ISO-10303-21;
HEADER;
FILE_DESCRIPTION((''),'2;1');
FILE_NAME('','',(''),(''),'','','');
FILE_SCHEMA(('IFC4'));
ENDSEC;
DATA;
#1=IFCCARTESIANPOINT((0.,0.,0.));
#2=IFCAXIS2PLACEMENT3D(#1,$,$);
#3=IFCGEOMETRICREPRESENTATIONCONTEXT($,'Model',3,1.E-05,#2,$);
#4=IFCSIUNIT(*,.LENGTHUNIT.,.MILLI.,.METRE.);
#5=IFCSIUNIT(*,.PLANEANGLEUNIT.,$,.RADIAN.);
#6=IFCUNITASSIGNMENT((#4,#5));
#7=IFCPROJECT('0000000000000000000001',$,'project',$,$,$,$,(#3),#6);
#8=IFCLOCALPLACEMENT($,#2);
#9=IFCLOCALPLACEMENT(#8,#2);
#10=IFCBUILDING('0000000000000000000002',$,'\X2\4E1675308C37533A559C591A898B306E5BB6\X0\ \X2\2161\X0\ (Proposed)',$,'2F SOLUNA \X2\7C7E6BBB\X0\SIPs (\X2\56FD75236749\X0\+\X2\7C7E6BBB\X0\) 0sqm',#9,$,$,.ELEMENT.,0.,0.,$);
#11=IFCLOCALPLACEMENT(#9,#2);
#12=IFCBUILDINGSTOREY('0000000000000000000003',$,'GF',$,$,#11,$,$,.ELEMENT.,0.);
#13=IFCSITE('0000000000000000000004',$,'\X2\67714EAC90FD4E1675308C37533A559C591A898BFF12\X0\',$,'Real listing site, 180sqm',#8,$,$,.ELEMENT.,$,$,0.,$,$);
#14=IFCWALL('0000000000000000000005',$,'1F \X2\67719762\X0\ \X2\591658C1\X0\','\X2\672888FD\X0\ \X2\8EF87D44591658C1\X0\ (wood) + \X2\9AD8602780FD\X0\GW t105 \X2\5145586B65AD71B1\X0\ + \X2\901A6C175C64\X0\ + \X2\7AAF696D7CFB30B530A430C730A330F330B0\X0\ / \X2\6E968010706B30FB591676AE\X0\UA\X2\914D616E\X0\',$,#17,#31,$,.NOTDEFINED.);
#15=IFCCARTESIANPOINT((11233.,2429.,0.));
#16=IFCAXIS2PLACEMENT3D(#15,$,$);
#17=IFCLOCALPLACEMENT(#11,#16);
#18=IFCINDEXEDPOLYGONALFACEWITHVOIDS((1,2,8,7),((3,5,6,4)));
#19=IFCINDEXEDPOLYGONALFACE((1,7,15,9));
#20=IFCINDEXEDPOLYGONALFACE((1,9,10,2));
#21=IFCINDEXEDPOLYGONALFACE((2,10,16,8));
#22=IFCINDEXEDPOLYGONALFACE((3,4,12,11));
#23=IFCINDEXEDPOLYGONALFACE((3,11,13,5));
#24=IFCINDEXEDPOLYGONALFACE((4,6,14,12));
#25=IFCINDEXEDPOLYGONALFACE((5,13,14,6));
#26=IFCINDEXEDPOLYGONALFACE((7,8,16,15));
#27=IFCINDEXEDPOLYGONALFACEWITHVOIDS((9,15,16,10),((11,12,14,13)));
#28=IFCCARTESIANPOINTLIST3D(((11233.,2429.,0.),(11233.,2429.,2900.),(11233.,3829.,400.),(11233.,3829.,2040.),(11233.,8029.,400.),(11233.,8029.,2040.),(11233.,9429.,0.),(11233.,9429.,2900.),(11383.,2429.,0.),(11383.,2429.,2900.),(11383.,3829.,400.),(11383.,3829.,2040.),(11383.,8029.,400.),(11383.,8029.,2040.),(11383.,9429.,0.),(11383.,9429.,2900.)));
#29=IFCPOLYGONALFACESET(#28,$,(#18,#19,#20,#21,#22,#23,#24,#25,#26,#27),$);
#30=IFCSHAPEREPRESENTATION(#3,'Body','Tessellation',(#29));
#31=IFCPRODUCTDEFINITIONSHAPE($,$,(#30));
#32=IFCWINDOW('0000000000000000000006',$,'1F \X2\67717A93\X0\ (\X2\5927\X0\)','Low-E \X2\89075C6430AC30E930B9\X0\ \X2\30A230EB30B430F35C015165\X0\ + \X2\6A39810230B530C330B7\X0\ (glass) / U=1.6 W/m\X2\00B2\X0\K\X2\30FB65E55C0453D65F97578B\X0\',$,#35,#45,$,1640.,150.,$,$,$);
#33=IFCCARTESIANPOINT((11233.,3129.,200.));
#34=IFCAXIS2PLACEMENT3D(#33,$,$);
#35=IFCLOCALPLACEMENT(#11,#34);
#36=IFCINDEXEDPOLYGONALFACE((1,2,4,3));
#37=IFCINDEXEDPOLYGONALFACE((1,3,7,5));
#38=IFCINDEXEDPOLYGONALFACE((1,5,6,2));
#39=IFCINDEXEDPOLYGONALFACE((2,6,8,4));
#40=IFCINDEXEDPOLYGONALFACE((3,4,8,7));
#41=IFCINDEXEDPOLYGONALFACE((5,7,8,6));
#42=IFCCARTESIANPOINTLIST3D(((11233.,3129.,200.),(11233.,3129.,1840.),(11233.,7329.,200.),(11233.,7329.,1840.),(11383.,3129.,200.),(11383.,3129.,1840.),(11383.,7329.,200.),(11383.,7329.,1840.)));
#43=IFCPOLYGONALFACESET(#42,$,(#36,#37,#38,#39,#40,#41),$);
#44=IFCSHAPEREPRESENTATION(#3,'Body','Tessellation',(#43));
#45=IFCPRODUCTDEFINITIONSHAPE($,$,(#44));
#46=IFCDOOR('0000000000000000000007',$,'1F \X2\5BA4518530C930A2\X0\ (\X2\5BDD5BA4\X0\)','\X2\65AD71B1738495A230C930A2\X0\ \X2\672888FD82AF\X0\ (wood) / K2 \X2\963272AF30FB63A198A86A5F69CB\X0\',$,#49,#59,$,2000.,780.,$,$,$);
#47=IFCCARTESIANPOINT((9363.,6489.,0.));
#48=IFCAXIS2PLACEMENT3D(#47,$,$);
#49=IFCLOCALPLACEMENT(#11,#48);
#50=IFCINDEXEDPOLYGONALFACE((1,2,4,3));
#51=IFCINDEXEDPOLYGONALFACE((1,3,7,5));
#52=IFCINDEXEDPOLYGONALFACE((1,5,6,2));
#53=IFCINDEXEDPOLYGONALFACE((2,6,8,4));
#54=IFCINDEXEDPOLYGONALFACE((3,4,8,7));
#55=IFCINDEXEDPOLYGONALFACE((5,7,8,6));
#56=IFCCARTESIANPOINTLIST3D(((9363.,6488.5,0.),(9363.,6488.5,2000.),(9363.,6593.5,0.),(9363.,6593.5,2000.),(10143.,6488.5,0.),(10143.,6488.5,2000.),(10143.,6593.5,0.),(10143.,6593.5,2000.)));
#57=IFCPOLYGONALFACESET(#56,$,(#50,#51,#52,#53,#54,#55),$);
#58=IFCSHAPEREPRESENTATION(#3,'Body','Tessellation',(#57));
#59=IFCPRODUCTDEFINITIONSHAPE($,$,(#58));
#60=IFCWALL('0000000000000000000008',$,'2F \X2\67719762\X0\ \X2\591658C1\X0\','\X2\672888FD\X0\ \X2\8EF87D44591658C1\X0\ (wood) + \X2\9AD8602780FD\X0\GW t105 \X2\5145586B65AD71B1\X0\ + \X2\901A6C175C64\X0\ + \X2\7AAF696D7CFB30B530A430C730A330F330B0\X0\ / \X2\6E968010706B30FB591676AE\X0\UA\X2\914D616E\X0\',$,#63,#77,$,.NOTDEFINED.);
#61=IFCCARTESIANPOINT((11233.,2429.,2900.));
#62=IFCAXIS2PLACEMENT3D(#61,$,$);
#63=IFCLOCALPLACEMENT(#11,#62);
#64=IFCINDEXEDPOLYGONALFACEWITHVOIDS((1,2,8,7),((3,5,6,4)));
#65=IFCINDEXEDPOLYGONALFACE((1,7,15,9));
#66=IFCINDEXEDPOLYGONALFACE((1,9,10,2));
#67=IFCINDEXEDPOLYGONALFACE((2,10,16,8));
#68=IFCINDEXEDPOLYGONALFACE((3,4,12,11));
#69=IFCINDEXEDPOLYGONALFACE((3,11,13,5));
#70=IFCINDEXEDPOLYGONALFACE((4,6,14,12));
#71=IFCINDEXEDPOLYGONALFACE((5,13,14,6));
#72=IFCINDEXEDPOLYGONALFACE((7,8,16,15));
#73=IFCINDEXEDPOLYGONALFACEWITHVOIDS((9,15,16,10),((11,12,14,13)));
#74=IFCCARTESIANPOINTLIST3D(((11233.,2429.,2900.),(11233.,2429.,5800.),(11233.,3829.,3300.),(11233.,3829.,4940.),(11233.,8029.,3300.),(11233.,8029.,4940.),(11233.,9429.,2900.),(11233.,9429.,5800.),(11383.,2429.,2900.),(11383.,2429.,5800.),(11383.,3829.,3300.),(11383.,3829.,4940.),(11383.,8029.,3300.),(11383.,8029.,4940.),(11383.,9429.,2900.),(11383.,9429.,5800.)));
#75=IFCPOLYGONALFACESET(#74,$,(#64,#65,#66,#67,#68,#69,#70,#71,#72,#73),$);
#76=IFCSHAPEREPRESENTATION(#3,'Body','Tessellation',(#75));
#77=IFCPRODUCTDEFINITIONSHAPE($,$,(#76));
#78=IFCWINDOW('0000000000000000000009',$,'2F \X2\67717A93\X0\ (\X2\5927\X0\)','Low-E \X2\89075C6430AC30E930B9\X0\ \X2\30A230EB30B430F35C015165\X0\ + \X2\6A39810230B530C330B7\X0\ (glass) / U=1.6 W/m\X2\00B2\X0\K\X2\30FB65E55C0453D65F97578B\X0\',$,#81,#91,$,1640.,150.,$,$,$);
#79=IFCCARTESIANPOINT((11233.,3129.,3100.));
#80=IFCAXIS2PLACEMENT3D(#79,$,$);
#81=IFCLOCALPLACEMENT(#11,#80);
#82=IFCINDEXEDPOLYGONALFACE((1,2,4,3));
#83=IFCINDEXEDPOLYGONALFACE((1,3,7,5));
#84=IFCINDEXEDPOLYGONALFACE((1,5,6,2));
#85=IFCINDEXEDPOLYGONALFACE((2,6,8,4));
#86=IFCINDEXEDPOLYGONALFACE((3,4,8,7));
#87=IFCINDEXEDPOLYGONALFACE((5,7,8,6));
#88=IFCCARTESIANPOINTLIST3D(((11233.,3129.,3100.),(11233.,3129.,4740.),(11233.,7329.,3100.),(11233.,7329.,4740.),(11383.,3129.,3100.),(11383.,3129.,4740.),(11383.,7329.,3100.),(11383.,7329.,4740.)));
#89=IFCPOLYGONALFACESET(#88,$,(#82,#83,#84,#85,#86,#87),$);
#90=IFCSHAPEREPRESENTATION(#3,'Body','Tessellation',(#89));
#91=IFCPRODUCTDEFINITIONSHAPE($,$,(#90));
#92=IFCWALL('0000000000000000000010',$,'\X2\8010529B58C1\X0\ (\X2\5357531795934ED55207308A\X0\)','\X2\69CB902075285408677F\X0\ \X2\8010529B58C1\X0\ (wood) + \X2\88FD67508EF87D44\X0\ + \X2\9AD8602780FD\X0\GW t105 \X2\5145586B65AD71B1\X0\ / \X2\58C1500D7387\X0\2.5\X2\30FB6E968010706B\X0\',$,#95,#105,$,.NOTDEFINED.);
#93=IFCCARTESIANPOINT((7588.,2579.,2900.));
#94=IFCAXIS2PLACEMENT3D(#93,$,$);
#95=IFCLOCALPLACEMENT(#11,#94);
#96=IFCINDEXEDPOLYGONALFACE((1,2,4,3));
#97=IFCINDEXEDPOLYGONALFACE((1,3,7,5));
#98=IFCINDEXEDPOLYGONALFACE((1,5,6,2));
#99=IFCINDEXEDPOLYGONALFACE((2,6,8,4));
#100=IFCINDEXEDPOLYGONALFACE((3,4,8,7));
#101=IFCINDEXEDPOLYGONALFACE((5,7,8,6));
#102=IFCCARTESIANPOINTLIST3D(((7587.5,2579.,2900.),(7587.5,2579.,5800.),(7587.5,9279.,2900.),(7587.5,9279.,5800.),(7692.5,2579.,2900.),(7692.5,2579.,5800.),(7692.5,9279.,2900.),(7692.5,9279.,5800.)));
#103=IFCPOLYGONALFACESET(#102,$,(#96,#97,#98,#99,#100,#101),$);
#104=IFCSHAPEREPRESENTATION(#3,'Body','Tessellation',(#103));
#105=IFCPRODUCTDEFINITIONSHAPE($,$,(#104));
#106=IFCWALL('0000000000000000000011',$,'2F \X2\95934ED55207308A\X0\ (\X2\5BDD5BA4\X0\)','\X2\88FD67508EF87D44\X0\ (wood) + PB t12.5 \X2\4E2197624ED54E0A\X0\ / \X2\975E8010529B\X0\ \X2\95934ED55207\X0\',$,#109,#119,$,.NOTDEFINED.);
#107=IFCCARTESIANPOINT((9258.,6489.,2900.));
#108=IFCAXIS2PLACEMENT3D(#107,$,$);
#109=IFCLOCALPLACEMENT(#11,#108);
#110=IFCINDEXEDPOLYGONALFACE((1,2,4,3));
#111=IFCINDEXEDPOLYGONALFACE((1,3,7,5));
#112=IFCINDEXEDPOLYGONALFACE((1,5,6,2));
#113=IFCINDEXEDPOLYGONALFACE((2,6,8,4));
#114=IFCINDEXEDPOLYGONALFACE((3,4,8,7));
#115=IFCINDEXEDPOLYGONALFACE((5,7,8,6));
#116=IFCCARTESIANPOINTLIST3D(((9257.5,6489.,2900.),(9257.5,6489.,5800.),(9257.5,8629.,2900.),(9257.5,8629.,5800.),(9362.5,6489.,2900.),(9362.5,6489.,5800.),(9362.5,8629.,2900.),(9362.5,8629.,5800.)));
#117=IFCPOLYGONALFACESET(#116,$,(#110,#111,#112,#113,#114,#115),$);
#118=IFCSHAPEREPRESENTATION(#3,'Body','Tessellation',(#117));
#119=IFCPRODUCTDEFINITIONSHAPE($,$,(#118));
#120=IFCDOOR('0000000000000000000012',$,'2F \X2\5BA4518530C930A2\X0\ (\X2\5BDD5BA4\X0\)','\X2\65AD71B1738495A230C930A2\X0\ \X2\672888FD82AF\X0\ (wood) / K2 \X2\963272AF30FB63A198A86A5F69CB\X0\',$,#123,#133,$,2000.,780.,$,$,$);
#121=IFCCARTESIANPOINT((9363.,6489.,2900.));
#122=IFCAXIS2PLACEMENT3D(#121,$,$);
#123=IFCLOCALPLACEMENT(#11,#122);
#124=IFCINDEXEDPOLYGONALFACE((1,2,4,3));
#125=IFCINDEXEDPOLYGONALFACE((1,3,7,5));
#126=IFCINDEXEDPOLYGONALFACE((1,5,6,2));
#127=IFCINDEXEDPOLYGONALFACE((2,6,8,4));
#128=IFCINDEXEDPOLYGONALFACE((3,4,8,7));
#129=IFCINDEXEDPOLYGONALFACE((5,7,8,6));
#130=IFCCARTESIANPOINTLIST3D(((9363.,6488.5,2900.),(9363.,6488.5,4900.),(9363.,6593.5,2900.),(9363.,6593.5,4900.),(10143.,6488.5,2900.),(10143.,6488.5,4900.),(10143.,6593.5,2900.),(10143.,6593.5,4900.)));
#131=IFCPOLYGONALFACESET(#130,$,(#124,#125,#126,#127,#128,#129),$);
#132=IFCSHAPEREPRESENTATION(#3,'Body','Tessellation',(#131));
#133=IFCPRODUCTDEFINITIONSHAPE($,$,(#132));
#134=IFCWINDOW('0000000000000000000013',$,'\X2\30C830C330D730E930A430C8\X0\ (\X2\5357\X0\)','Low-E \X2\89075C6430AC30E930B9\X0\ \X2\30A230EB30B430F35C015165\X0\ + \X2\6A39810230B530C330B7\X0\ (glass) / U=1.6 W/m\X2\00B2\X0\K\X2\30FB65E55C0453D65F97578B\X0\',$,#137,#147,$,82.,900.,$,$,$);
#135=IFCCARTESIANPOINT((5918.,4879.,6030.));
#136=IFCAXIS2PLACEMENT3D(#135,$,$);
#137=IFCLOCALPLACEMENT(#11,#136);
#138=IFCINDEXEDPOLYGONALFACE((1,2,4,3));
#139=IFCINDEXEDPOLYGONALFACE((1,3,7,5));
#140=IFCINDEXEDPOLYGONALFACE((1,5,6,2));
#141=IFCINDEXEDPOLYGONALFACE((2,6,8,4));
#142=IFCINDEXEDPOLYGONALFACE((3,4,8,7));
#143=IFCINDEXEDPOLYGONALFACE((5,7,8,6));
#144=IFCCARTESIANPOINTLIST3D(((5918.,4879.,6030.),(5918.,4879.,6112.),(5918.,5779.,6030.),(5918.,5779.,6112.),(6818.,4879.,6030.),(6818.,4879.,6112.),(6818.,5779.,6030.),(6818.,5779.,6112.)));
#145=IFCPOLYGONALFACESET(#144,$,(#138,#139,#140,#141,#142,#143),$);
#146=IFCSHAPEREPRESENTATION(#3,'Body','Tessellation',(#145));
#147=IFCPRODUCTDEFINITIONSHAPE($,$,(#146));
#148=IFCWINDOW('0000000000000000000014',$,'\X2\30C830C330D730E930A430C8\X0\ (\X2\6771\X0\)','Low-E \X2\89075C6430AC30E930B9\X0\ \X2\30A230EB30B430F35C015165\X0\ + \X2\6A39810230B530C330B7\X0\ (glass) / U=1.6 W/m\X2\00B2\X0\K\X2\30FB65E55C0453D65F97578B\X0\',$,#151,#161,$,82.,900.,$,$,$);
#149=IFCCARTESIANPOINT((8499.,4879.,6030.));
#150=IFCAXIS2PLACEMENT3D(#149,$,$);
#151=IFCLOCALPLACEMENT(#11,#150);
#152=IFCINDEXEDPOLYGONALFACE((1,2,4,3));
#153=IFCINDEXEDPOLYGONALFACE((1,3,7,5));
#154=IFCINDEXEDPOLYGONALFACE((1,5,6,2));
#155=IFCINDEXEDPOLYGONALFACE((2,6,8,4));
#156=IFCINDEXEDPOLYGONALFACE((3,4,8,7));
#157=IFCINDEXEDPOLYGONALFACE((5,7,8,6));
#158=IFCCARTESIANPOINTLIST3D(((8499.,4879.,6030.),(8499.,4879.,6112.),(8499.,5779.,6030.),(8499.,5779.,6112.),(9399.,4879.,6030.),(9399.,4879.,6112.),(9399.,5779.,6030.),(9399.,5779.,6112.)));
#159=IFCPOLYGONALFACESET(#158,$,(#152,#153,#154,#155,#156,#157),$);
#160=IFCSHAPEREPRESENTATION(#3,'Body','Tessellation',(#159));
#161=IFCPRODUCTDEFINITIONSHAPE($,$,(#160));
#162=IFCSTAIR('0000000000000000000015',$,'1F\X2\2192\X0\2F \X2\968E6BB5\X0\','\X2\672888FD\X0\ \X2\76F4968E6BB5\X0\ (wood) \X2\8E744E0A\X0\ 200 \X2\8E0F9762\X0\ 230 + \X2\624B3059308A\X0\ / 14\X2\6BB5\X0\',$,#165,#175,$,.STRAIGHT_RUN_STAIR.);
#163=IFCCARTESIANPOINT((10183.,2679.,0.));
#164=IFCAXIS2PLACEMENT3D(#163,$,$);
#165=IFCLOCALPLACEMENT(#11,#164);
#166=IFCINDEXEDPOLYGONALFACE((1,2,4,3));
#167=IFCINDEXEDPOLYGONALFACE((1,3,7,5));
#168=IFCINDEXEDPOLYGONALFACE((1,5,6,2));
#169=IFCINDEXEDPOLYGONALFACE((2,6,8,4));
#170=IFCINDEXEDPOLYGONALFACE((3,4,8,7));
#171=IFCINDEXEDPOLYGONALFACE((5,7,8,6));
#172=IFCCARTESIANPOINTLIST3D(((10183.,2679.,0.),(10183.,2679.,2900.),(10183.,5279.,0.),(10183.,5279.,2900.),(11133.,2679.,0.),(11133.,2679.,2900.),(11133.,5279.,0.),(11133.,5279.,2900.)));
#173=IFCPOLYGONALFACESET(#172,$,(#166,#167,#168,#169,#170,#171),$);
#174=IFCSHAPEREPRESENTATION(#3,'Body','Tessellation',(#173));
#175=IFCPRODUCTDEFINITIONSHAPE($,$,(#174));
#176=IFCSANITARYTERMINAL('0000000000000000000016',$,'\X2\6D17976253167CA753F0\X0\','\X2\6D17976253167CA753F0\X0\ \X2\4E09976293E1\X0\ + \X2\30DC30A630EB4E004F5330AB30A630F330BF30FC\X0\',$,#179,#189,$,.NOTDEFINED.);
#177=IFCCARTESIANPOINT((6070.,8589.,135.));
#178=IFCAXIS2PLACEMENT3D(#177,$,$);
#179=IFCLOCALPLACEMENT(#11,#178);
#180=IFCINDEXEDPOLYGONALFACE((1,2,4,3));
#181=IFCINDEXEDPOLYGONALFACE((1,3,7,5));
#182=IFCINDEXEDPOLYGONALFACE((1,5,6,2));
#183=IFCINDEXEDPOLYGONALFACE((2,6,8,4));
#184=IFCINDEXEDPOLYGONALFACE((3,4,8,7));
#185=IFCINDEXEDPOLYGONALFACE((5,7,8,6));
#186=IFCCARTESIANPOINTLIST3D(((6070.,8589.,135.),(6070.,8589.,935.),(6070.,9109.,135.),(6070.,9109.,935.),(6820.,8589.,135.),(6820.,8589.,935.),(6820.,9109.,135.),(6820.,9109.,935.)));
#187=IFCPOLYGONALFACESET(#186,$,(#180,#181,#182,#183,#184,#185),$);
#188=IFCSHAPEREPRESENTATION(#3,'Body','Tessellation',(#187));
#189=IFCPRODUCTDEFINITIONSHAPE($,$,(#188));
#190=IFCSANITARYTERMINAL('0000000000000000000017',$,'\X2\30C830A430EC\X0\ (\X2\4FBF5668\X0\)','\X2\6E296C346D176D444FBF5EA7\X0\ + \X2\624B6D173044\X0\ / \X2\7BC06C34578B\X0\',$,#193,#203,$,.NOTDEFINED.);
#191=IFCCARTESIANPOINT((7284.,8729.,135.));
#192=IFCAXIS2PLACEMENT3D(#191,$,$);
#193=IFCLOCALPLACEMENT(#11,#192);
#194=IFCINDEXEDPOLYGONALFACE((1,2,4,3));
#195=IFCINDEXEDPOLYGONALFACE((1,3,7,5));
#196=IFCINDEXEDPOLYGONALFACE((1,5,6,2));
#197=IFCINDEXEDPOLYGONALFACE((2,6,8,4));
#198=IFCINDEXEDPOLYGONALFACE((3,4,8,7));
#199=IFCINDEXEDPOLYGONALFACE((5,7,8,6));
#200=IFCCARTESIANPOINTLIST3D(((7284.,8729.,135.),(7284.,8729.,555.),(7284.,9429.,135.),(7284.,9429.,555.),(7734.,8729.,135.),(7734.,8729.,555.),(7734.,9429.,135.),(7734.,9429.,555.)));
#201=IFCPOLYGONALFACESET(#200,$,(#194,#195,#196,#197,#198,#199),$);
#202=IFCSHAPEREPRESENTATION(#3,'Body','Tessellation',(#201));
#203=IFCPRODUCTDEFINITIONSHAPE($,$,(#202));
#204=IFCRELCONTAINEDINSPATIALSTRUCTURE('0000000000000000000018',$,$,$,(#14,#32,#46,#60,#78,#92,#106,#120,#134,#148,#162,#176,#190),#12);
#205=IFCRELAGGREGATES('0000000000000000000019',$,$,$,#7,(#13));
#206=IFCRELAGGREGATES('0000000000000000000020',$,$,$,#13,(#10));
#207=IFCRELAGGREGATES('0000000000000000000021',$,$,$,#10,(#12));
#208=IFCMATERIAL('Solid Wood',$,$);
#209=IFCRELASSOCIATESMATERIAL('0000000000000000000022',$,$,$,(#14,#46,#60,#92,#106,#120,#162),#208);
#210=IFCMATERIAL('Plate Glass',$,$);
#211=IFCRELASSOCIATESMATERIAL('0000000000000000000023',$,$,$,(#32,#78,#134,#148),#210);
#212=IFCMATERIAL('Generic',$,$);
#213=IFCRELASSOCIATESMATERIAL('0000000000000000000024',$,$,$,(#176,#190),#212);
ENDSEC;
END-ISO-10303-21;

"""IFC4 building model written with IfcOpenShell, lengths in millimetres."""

from ifc_helpers import new_model, si_unit, frame, frame_2d, origin, place, context, project, spatial, rectangle, extrude, material, element, fill, save


model = new_model("IFC4")

# Units and contexts
model_context = context("Model", 3, precision=1e-05, world=origin())
ifc_project = project(units=[si_unit("LENGTHUNIT", "METRE", prefix="MILLI"), si_unit("PLANEANGLEUNIT", "RADIAN")], contexts=[model_context])

# Site, building, storey
site_placement = place(None, origin())
site = spatial("IfcSite", under=ifc_project, at=site_placement, Name="東京都世田谷区喜多見２", ObjectType="Real listing site, 180sqm", CompositionType="ELEMENT", RefElevation=0.0)
building_placement = place(site_placement, origin())
building = spatial("IfcBuilding", under=site, at=building_placement, Name="世田谷区喜多見の家 Ⅱ (Proposed)", ObjectType="2F SOLUNA 籾殻SIPs (国産杉+籾殻) 0sqm", CompositionType="ELEMENT", ElevationOfRefHeight=0.0, ElevationOfTerrain=0.0)
storey_placement = place(building_placement, origin())
storey = spatial("IfcBuildingStorey", under=building, at=storey_placement, Name="GF", CompositionType="ELEMENT", Elevation=0.0)

# Wall, opening, window
ifc_material_1 = material(Name="Solid Wood")
wall_1_placement = place(storey_placement, frame((11233.0, 2429.0, 0.0)))
wall_1 = element("IfcWall", 1, at=wall_1_placement, inside=storey, material=ifc_material_1, Name="1F 東面 外壁", Description="木製 軸組外壁 (wood) + 高性能GW t105 充填断熱 + 通気層 + 窯業系サイディング / 準耐火・外皮UA配慮", PredefinedType="NOTDEFINED", context=model_context, shape_type="SweptSolid", body=[
    extrude(rectangle(XDim=150.0, YDim=7000.0, at=frame_2d((75.0, 3500.0))), frame((11233.0, 2429.0, 0.0)), (0.0, 0.0, 1.0), 2900.0),
])
opening_1_placement = place(storey_placement, frame((11233.0, 3129.0, 200.0)))
opening_1 = element("IfcOpeningElement", 2, at=opening_1_placement, cuts=wall_1, PredefinedType="NOTDEFINED", context=model_context, shape_type="SweptSolid", body=[
    extrude(rectangle(XDim=150.0, YDim=4200.0, at=frame_2d((75.0, 2100.0))), frame((11233.0, 3129.0, 200.0)), (0.0, 0.0, 1.0), 1640.0),
])
ifc_material_2 = material(Name="Plate Glass")
window_1_placement = place(storey_placement, frame((11233.0, 3129.0, 200.0)))
window_1 = element("IfcWindow", 3, at=window_1_placement, inside=storey, material=ifc_material_2, Name="1F 東窓 (大)", Description="Low-E 複層ガラス アルゴン封入 + 樹脂サッシ (glass) / U=1.6 W/m²K・日射取得型", OverallHeight=1640.0, OverallWidth=150.0, context=model_context, shape_type="SweptSolid", body=[
    extrude(rectangle(XDim=150.0, YDim=4200.0, at=frame_2d((75.0, 2100.0))), frame((11233.0, 3129.0, 200.0)), (0.0, 0.0, 1.0), 1640.0),
])
fill(opening_1, window_1)

# Door
door_1_placement = place(storey_placement, frame((9363.0, 6489.0, 0.0)))
element("IfcDoor", 4, at=door_1_placement, inside=storey, material=ifc_material_1, Name="1F 室内ドア (寝室)", Description="断熱玄関ドア 木製芯 (wood) / K2 防犯・採風機構", OverallHeight=2000.0, OverallWidth=780.0, context=model_context, shape_type="SweptSolid", body=[
    extrude(rectangle(XDim=780.0, YDim=105.0, at=frame_2d((390.0, 52.0))), frame((9363.0, 6489.0, 0.0)), (0.0, 0.0, 1.0), 2000.0),
])

# Wall, opening, window
wall_2_placement = place(storey_placement, frame((11233.0, 2429.0, 2900.0)))
wall_2 = element("IfcWall", 5, at=wall_2_placement, inside=storey, material=ifc_material_1, Name="2F 東面 外壁", Description="木製 軸組外壁 (wood) + 高性能GW t105 充填断熱 + 通気層 + 窯業系サイディング / 準耐火・外皮UA配慮", PredefinedType="NOTDEFINED", context=model_context, shape_type="SweptSolid", body=[
    extrude(rectangle(XDim=150.0, YDim=7000.0, at=frame_2d((75.0, 3500.0))), frame((11233.0, 2429.0, 2900.0)), (0.0, 0.0, 1.0), 2900.0),
])
opening_2_placement = place(storey_placement, frame((11233.0, 3129.0, 3100.0)))
opening_2 = element("IfcOpeningElement", 6, at=opening_2_placement, cuts=wall_2, PredefinedType="NOTDEFINED", context=model_context, shape_type="SweptSolid", body=[
    extrude(rectangle(XDim=150.0, YDim=4200.0, at=frame_2d((75.0, 2100.0))), frame((11233.0, 3129.0, 3100.0)), (0.0, 0.0, 1.0), 1640.0),
])
window_2_placement = place(storey_placement, frame((11233.0, 3129.0, 3100.0)))
window_2 = element("IfcWindow", 7, at=window_2_placement, inside=storey, material=ifc_material_2, Name="2F 東窓 (大)", Description="Low-E 複層ガラス アルゴン封入 + 樹脂サッシ (glass) / U=1.6 W/m²K・日射取得型", OverallHeight=1640.0, OverallWidth=150.0, context=model_context, shape_type="SweptSolid", body=[
    extrude(rectangle(XDim=150.0, YDim=4200.0, at=frame_2d((75.0, 2100.0))), frame((11233.0, 3129.0, 3100.0)), (0.0, 0.0, 1.0), 1640.0),
])
fill(opening_2, window_2)

# Walls
wall_3_placement = place(storey_placement, frame((7588.0, 2579.0, 2900.0)))
element("IfcWall", 8, at=wall_3_placement, inside=storey, material=ifc_material_1, Name="耐力壁 (南北間仕切り)", Description="構造用合板 耐力壁 (wood) + 製材軸組 + 高性能GW t105 充填断熱 / 壁倍率2.5・準耐火", PredefinedType="NOTDEFINED", context=model_context, shape_type="SweptSolid", body=[
    extrude(rectangle(XDim=105.0, YDim=6700.0, at=frame_2d((52.0, 3350.0))), frame((7588.0, 2579.0, 2900.0)), (0.0, 0.0, 1.0), 2900.0),
])
wall_4_placement = place(storey_placement, frame((9258.0, 6489.0, 2900.0)))
element("IfcWall", 9, at=wall_4_placement, inside=storey, material=ifc_material_1, Name="2F 間仕切り (寝室)", Description="製材軸組 (wood) + PB t12.5 両面仕上 / 非耐力 間仕切", PredefinedType="NOTDEFINED", context=model_context, shape_type="SweptSolid", body=[
    extrude(rectangle(XDim=105.0, YDim=2140.0, at=frame_2d((52.0, 1070.0))), frame((9258.0, 6489.0, 2900.0)), (0.0, 0.0, 1.0), 2900.0),
])

# Door
door_2_placement = place(storey_placement, frame((9363.0, 6489.0, 2900.0)))
element("IfcDoor", 10, at=door_2_placement, inside=storey, material=ifc_material_1, Name="2F 室内ドア (寝室)", Description="断熱玄関ドア 木製芯 (wood) / K2 防犯・採風機構", OverallHeight=2000.0, OverallWidth=780.0, context=model_context, shape_type="SweptSolid", body=[
    extrude(rectangle(XDim=780.0, YDim=105.0, at=frame_2d((390.0, 52.0))), frame((9363.0, 6489.0, 2900.0)), (0.0, 0.0, 1.0), 2000.0),
])

# Windows
window_3_placement = place(storey_placement, frame((5918.0, 4879.0, 6030.0)))
element("IfcWindow", 11, at=window_3_placement, inside=storey, material=ifc_material_2, Name="トップライト (南)", Description="Low-E 複層ガラス アルゴン封入 + 樹脂サッシ (glass) / U=1.6 W/m²K・日射取得型", OverallHeight=82.0, OverallWidth=900.0, context=model_context, shape_type="SweptSolid", body=[
    extrude(rectangle(XDim=900.0, YDim=900.0, at=frame_2d((450.0, 450.0))), frame((5918.0, 4879.0, 6030.0)), (0.0, 0.0, 1.0), 82.0),
])
window_4_placement = place(storey_placement, frame((8499.0, 4879.0, 6030.0)))
element("IfcWindow", 12, at=window_4_placement, inside=storey, material=ifc_material_2, Name="トップライト (東)", Description="Low-E 複層ガラス アルゴン封入 + 樹脂サッシ (glass) / U=1.6 W/m²K・日射取得型", OverallHeight=82.0, OverallWidth=900.0, context=model_context, shape_type="SweptSolid", body=[
    extrude(rectangle(XDim=900.0, YDim=900.0, at=frame_2d((450.0, 450.0))), frame((8499.0, 4879.0, 6030.0)), (0.0, 0.0, 1.0), 82.0),
])

# Stair
stair_placement = place(storey_placement, frame((10183.0, 2679.0, 0.0)))
element("IfcStair", 13, at=stair_placement, inside=storey, material=ifc_material_1, Name="1F→2F 階段", Description="木製 直階段 (wood) 蹴上 200 踏面 230 + 手すり / 14段", PredefinedType="STRAIGHT_RUN_STAIR", context=model_context, shape_type="SweptSolid", body=[
    extrude(rectangle(XDim=950.0, YDim=2600.0, at=frame_2d((475.0, 1300.0))), frame((10183.0, 2679.0, 0.0)), (0.0, 0.0, 1.0), 2900.0),
])

# Sanitary terminals
ifc_material_3 = material(Name="Generic")
sanitary_terminal_1_placement = place(storey_placement, frame((6070.0, 8589.0, 135.0)))
element("IfcSanitaryTerminal", 14, at=sanitary_terminal_1_placement, inside=storey, material=ifc_material_3, Name="洗面化粧台", Description="洗面化粧台 三面鏡 + ボウル一体カウンター", PredefinedType="NOTDEFINED", context=model_context, shape_type="SweptSolid", body=[
    extrude(rectangle(XDim=750.0, YDim=520.0, at=frame_2d((375.0, 260.0))), frame((6070.0, 8589.0, 135.0)), (0.0, 0.0, 1.0), 800.0),
])
sanitary_terminal_2_placement = place(storey_placement, frame((7284.0, 8729.0, 135.0)))
element("IfcSanitaryTerminal", 15, at=sanitary_terminal_2_placement, inside=storey, material=ifc_material_3, Name="トイレ (便器)", Description="温水洗浄便座 + 手洗い / 節水型", PredefinedType="NOTDEFINED", context=model_context, shape_type="SweptSolid", body=[
    extrude(rectangle(XDim=450.0, YDim=700.0, at=frame_2d((225.0, 350.0))), frame((7284.0, 8729.0, 135.0)), (0.0, 0.0, 1.0), 420.0),
])

save(model, "model.ifc")
